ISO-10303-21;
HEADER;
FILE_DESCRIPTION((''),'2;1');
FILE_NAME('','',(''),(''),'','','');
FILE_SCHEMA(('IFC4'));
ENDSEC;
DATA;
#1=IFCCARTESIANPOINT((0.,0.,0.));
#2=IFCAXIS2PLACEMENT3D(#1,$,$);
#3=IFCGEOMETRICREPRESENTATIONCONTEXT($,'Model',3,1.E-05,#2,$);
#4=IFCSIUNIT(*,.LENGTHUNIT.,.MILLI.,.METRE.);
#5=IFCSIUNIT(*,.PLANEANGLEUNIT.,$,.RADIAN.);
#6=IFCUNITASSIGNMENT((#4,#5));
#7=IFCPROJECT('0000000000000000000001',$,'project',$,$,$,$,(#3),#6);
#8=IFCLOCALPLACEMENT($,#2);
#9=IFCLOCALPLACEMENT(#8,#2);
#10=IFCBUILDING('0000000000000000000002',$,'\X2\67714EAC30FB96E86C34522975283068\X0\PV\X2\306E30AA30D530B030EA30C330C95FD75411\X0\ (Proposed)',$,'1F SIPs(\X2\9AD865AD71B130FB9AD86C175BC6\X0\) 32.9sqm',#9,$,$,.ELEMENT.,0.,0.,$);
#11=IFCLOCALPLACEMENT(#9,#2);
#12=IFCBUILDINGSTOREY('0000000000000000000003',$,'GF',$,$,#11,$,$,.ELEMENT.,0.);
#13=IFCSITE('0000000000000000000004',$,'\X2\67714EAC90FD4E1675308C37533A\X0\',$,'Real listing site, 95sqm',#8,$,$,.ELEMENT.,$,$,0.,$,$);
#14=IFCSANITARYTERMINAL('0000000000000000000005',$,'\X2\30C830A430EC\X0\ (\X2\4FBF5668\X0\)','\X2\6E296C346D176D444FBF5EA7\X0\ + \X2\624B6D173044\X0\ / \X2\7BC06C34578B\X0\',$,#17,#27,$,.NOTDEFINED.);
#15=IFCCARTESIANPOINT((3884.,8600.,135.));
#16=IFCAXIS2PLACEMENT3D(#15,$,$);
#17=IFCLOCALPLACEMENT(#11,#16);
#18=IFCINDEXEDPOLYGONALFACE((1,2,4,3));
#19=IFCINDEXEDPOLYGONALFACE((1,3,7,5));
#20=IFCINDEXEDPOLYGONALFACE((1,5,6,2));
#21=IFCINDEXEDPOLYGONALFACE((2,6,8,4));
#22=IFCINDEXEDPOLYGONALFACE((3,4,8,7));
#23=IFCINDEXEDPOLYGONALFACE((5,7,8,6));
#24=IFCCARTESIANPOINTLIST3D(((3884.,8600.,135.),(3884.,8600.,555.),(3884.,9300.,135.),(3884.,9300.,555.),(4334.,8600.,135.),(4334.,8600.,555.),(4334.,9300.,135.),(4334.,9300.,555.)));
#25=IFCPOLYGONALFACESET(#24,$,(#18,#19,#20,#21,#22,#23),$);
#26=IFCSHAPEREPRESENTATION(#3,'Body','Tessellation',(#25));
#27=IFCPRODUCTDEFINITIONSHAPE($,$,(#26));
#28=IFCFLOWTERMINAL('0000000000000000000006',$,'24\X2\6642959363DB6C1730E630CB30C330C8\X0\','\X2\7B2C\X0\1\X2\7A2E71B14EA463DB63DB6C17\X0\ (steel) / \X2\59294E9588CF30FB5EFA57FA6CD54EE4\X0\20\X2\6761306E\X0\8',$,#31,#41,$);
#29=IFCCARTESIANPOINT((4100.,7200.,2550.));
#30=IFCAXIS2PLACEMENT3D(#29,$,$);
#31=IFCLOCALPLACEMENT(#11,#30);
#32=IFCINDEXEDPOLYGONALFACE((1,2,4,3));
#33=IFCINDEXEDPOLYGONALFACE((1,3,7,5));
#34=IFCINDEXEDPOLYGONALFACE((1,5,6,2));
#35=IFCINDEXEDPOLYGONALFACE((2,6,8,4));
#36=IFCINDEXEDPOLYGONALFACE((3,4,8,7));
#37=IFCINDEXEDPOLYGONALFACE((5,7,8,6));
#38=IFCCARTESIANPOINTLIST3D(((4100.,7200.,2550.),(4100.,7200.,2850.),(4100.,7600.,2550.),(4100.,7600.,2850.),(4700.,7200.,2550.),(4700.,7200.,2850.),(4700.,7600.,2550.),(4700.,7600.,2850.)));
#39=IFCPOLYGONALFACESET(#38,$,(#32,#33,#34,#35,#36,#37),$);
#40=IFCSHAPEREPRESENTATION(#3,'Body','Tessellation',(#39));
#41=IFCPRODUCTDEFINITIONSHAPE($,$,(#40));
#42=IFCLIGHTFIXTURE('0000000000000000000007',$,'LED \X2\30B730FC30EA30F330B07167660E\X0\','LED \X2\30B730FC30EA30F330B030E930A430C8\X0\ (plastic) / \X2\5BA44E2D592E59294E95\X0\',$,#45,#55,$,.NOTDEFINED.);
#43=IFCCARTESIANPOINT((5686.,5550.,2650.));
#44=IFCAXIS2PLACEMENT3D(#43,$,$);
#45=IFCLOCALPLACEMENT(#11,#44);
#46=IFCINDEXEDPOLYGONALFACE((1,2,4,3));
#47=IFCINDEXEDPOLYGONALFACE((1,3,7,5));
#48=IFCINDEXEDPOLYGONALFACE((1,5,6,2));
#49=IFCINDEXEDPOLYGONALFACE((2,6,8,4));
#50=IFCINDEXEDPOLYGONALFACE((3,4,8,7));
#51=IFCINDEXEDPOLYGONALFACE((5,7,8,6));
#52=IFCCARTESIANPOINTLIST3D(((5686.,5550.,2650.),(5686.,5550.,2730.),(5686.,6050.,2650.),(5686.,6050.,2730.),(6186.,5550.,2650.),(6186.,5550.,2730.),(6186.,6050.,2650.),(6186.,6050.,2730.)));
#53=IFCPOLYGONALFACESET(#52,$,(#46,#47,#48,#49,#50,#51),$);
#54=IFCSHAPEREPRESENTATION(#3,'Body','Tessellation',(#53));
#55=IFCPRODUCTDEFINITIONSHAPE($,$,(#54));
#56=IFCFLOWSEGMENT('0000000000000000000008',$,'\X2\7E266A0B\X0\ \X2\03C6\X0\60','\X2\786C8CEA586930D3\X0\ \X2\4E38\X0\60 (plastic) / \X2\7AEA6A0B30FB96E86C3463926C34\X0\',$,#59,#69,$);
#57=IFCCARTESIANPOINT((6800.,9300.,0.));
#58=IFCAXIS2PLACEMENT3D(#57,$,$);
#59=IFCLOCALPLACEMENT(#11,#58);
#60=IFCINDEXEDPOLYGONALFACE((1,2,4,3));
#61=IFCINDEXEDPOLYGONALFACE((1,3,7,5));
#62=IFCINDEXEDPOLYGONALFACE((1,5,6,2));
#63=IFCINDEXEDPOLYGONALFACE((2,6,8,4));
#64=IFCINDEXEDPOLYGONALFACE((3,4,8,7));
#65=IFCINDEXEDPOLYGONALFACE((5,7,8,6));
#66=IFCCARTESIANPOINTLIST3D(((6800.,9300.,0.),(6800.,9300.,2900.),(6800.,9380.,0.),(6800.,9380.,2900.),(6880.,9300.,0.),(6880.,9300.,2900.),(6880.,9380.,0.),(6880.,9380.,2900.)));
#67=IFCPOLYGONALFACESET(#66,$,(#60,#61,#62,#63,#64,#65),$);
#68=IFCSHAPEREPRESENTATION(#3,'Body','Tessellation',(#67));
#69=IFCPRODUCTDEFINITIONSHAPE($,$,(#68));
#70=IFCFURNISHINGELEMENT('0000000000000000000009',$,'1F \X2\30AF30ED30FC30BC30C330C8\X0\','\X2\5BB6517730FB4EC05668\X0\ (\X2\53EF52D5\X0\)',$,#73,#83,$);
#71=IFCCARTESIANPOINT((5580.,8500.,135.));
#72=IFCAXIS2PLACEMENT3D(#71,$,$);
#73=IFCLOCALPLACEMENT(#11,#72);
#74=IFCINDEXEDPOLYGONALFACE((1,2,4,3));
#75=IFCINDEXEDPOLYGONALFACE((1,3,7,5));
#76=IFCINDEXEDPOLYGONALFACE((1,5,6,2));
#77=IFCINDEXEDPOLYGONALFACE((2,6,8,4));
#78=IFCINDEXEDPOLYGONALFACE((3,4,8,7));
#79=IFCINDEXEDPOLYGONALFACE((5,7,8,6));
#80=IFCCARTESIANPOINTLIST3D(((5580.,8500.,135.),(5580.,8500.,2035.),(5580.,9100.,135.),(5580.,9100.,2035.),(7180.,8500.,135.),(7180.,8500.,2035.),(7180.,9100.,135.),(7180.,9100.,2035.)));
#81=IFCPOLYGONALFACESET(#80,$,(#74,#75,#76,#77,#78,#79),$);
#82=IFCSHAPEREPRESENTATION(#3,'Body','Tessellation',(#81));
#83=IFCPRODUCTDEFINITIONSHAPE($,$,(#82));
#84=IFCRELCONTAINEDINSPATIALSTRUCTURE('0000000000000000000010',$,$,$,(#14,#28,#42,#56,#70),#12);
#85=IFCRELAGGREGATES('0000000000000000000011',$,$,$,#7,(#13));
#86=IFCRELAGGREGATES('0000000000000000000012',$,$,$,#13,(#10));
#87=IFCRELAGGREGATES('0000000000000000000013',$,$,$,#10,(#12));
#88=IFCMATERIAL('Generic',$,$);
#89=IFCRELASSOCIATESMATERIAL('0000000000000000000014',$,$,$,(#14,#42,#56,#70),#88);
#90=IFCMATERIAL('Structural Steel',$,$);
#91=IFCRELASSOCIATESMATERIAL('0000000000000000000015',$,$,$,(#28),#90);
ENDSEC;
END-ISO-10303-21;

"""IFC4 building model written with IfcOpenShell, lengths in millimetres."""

from ifc_helpers import new_model, si_unit, frame, frame_2d, origin, place, context, project, spatial, rectangle, extrude, material, element, save


model = new_model("IFC4")

# Units and contexts
model_context = context("Model", 3, precision=1e-05, world=origin())
ifc_project = project(units=[si_unit("LENGTHUNIT", "METRE", prefix="MILLI"), si_unit("PLANEANGLEUNIT", "RADIAN")], contexts=[model_context])

# Site, building, storey
site_placement = place(None, origin())
site = spatial("IfcSite", under=ifc_project, at=site_placement, Name="東京都世田谷区", ObjectType="Real listing site, 95sqm", CompositionType="ELEMENT", RefElevation=0.0)
building_placement = place(site_placement, origin())
building = spatial("IfcBuilding", under=site, at=building_placement, Name="東京・雨水利用とPVのオフグリッド志向 (Proposed)", ObjectType="1F SIPs(高断熱・高気密) 32.9sqm", CompositionType="ELEMENT", ElevationOfRefHeight=0.0, ElevationOfTerrain=0.0)
storey_placement = place(building_placement, origin())
storey = spatial("IfcBuildingStorey", under=building, at=storey_placement, Name="GF", CompositionType="ELEMENT", Elevation=0.0)

# Shared definitions
ifc_material_1 = material(Name="Generic")

# Sanitary terminal
sanitary_terminal_placement = place(storey_placement, frame((3884.0, 8600.0, 135.0)))
element("IfcSanitaryTerminal", 1, at=sanitary_terminal_placement, inside=storey, material=ifc_material_1, Name="トイレ (便器)", Description="温水洗浄便座 + 手洗い / 節水型", PredefinedType="NOTDEFINED", context=model_context, shape_type="SweptSolid", body=[
    extrude(rectangle(XDim=450.0, YDim=700.0, at=frame_2d((225.0, 350.0))), frame((3884.0, 8600.0, 135.0)), (0.0, 0.0, 1.0), 420.0),
])

# Flow terminal
ifc_material_2 = material(Name="Structural Steel")
flow_terminal_placement = place(storey_placement, frame((4100.0, 7200.0, 2550.0)))
element("IfcFlowTerminal", 2, at=flow_terminal_placement, inside=storey, material=ifc_material_2, Name="24時間換気ユニット", Description="第1種熱交換換気 (steel) / 天井裏・建基法令20条の8", context=model_context, shape_type="SweptSolid", body=[
    extrude(rectangle(XDim=600.0, YDim=400.0, at=frame_2d((300.0, 200.0))), frame((4100.0, 7200.0, 2550.0)), (0.0, 0.0, 1.0), 300.0),
])

# Light fixture
light_fixture_placement = place(storey_placement, frame((5686.0, 5550.0, 2650.0)))
element("IfcLightFixture", 3, at=light_fixture_placement, inside=storey, material=ifc_material_1, Name="LED シーリング照明", Description="LED シーリングライト (plastic) / 室中央天井", PredefinedType="NOTDEFINED", context=model_context, shape_type="SweptSolid", body=[
    extrude(rectangle(XDim=500.0, YDim=500.0, at=frame_2d((250.0, 250.0))), frame((5686.0, 5550.0, 2650.0)), (0.0, 0.0, 1.0), 80.0),
])

# Flow segment
flow_segment_placement = place(storey_placement, frame((6800.0, 9300.0, 0.0)))
element("IfcFlowSegment", 4, at=flow_segment_placement, inside=storey, material=ifc_material_1, Name="縦樋 φ60", Description="硬質塩ビ 丸60 (plastic) / 竪樋・雨水排水", context=model_context, shape_type="SweptSolid", body=[
    extrude(rectangle(XDim=80.0, YDim=80.0, at=frame_2d((40.0, 40.0))), frame((6800.0, 9300.0, 0.0)), (0.0, 0.0, 1.0), 2900.0),
])

# Furnishing element
furnishing_placement = place(storey_placement, frame((5580.0, 8500.0, 135.0)))
element("IfcFurnishingElement", 5, at=furnishing_placement, inside=storey, material=ifc_material_1, Name="1F クローゼット", Description="家具・什器 (可動)", context=model_context, shape_type="SweptSolid", body=[
    extrude(rectangle(XDim=1600.0, YDim=600.0, at=frame_2d((800.0, 300.0))), frame((5580.0, 8500.0, 135.0)), (0.0, 0.0, 1.0), 1900.0),
])

save(model, "model.ifc")
